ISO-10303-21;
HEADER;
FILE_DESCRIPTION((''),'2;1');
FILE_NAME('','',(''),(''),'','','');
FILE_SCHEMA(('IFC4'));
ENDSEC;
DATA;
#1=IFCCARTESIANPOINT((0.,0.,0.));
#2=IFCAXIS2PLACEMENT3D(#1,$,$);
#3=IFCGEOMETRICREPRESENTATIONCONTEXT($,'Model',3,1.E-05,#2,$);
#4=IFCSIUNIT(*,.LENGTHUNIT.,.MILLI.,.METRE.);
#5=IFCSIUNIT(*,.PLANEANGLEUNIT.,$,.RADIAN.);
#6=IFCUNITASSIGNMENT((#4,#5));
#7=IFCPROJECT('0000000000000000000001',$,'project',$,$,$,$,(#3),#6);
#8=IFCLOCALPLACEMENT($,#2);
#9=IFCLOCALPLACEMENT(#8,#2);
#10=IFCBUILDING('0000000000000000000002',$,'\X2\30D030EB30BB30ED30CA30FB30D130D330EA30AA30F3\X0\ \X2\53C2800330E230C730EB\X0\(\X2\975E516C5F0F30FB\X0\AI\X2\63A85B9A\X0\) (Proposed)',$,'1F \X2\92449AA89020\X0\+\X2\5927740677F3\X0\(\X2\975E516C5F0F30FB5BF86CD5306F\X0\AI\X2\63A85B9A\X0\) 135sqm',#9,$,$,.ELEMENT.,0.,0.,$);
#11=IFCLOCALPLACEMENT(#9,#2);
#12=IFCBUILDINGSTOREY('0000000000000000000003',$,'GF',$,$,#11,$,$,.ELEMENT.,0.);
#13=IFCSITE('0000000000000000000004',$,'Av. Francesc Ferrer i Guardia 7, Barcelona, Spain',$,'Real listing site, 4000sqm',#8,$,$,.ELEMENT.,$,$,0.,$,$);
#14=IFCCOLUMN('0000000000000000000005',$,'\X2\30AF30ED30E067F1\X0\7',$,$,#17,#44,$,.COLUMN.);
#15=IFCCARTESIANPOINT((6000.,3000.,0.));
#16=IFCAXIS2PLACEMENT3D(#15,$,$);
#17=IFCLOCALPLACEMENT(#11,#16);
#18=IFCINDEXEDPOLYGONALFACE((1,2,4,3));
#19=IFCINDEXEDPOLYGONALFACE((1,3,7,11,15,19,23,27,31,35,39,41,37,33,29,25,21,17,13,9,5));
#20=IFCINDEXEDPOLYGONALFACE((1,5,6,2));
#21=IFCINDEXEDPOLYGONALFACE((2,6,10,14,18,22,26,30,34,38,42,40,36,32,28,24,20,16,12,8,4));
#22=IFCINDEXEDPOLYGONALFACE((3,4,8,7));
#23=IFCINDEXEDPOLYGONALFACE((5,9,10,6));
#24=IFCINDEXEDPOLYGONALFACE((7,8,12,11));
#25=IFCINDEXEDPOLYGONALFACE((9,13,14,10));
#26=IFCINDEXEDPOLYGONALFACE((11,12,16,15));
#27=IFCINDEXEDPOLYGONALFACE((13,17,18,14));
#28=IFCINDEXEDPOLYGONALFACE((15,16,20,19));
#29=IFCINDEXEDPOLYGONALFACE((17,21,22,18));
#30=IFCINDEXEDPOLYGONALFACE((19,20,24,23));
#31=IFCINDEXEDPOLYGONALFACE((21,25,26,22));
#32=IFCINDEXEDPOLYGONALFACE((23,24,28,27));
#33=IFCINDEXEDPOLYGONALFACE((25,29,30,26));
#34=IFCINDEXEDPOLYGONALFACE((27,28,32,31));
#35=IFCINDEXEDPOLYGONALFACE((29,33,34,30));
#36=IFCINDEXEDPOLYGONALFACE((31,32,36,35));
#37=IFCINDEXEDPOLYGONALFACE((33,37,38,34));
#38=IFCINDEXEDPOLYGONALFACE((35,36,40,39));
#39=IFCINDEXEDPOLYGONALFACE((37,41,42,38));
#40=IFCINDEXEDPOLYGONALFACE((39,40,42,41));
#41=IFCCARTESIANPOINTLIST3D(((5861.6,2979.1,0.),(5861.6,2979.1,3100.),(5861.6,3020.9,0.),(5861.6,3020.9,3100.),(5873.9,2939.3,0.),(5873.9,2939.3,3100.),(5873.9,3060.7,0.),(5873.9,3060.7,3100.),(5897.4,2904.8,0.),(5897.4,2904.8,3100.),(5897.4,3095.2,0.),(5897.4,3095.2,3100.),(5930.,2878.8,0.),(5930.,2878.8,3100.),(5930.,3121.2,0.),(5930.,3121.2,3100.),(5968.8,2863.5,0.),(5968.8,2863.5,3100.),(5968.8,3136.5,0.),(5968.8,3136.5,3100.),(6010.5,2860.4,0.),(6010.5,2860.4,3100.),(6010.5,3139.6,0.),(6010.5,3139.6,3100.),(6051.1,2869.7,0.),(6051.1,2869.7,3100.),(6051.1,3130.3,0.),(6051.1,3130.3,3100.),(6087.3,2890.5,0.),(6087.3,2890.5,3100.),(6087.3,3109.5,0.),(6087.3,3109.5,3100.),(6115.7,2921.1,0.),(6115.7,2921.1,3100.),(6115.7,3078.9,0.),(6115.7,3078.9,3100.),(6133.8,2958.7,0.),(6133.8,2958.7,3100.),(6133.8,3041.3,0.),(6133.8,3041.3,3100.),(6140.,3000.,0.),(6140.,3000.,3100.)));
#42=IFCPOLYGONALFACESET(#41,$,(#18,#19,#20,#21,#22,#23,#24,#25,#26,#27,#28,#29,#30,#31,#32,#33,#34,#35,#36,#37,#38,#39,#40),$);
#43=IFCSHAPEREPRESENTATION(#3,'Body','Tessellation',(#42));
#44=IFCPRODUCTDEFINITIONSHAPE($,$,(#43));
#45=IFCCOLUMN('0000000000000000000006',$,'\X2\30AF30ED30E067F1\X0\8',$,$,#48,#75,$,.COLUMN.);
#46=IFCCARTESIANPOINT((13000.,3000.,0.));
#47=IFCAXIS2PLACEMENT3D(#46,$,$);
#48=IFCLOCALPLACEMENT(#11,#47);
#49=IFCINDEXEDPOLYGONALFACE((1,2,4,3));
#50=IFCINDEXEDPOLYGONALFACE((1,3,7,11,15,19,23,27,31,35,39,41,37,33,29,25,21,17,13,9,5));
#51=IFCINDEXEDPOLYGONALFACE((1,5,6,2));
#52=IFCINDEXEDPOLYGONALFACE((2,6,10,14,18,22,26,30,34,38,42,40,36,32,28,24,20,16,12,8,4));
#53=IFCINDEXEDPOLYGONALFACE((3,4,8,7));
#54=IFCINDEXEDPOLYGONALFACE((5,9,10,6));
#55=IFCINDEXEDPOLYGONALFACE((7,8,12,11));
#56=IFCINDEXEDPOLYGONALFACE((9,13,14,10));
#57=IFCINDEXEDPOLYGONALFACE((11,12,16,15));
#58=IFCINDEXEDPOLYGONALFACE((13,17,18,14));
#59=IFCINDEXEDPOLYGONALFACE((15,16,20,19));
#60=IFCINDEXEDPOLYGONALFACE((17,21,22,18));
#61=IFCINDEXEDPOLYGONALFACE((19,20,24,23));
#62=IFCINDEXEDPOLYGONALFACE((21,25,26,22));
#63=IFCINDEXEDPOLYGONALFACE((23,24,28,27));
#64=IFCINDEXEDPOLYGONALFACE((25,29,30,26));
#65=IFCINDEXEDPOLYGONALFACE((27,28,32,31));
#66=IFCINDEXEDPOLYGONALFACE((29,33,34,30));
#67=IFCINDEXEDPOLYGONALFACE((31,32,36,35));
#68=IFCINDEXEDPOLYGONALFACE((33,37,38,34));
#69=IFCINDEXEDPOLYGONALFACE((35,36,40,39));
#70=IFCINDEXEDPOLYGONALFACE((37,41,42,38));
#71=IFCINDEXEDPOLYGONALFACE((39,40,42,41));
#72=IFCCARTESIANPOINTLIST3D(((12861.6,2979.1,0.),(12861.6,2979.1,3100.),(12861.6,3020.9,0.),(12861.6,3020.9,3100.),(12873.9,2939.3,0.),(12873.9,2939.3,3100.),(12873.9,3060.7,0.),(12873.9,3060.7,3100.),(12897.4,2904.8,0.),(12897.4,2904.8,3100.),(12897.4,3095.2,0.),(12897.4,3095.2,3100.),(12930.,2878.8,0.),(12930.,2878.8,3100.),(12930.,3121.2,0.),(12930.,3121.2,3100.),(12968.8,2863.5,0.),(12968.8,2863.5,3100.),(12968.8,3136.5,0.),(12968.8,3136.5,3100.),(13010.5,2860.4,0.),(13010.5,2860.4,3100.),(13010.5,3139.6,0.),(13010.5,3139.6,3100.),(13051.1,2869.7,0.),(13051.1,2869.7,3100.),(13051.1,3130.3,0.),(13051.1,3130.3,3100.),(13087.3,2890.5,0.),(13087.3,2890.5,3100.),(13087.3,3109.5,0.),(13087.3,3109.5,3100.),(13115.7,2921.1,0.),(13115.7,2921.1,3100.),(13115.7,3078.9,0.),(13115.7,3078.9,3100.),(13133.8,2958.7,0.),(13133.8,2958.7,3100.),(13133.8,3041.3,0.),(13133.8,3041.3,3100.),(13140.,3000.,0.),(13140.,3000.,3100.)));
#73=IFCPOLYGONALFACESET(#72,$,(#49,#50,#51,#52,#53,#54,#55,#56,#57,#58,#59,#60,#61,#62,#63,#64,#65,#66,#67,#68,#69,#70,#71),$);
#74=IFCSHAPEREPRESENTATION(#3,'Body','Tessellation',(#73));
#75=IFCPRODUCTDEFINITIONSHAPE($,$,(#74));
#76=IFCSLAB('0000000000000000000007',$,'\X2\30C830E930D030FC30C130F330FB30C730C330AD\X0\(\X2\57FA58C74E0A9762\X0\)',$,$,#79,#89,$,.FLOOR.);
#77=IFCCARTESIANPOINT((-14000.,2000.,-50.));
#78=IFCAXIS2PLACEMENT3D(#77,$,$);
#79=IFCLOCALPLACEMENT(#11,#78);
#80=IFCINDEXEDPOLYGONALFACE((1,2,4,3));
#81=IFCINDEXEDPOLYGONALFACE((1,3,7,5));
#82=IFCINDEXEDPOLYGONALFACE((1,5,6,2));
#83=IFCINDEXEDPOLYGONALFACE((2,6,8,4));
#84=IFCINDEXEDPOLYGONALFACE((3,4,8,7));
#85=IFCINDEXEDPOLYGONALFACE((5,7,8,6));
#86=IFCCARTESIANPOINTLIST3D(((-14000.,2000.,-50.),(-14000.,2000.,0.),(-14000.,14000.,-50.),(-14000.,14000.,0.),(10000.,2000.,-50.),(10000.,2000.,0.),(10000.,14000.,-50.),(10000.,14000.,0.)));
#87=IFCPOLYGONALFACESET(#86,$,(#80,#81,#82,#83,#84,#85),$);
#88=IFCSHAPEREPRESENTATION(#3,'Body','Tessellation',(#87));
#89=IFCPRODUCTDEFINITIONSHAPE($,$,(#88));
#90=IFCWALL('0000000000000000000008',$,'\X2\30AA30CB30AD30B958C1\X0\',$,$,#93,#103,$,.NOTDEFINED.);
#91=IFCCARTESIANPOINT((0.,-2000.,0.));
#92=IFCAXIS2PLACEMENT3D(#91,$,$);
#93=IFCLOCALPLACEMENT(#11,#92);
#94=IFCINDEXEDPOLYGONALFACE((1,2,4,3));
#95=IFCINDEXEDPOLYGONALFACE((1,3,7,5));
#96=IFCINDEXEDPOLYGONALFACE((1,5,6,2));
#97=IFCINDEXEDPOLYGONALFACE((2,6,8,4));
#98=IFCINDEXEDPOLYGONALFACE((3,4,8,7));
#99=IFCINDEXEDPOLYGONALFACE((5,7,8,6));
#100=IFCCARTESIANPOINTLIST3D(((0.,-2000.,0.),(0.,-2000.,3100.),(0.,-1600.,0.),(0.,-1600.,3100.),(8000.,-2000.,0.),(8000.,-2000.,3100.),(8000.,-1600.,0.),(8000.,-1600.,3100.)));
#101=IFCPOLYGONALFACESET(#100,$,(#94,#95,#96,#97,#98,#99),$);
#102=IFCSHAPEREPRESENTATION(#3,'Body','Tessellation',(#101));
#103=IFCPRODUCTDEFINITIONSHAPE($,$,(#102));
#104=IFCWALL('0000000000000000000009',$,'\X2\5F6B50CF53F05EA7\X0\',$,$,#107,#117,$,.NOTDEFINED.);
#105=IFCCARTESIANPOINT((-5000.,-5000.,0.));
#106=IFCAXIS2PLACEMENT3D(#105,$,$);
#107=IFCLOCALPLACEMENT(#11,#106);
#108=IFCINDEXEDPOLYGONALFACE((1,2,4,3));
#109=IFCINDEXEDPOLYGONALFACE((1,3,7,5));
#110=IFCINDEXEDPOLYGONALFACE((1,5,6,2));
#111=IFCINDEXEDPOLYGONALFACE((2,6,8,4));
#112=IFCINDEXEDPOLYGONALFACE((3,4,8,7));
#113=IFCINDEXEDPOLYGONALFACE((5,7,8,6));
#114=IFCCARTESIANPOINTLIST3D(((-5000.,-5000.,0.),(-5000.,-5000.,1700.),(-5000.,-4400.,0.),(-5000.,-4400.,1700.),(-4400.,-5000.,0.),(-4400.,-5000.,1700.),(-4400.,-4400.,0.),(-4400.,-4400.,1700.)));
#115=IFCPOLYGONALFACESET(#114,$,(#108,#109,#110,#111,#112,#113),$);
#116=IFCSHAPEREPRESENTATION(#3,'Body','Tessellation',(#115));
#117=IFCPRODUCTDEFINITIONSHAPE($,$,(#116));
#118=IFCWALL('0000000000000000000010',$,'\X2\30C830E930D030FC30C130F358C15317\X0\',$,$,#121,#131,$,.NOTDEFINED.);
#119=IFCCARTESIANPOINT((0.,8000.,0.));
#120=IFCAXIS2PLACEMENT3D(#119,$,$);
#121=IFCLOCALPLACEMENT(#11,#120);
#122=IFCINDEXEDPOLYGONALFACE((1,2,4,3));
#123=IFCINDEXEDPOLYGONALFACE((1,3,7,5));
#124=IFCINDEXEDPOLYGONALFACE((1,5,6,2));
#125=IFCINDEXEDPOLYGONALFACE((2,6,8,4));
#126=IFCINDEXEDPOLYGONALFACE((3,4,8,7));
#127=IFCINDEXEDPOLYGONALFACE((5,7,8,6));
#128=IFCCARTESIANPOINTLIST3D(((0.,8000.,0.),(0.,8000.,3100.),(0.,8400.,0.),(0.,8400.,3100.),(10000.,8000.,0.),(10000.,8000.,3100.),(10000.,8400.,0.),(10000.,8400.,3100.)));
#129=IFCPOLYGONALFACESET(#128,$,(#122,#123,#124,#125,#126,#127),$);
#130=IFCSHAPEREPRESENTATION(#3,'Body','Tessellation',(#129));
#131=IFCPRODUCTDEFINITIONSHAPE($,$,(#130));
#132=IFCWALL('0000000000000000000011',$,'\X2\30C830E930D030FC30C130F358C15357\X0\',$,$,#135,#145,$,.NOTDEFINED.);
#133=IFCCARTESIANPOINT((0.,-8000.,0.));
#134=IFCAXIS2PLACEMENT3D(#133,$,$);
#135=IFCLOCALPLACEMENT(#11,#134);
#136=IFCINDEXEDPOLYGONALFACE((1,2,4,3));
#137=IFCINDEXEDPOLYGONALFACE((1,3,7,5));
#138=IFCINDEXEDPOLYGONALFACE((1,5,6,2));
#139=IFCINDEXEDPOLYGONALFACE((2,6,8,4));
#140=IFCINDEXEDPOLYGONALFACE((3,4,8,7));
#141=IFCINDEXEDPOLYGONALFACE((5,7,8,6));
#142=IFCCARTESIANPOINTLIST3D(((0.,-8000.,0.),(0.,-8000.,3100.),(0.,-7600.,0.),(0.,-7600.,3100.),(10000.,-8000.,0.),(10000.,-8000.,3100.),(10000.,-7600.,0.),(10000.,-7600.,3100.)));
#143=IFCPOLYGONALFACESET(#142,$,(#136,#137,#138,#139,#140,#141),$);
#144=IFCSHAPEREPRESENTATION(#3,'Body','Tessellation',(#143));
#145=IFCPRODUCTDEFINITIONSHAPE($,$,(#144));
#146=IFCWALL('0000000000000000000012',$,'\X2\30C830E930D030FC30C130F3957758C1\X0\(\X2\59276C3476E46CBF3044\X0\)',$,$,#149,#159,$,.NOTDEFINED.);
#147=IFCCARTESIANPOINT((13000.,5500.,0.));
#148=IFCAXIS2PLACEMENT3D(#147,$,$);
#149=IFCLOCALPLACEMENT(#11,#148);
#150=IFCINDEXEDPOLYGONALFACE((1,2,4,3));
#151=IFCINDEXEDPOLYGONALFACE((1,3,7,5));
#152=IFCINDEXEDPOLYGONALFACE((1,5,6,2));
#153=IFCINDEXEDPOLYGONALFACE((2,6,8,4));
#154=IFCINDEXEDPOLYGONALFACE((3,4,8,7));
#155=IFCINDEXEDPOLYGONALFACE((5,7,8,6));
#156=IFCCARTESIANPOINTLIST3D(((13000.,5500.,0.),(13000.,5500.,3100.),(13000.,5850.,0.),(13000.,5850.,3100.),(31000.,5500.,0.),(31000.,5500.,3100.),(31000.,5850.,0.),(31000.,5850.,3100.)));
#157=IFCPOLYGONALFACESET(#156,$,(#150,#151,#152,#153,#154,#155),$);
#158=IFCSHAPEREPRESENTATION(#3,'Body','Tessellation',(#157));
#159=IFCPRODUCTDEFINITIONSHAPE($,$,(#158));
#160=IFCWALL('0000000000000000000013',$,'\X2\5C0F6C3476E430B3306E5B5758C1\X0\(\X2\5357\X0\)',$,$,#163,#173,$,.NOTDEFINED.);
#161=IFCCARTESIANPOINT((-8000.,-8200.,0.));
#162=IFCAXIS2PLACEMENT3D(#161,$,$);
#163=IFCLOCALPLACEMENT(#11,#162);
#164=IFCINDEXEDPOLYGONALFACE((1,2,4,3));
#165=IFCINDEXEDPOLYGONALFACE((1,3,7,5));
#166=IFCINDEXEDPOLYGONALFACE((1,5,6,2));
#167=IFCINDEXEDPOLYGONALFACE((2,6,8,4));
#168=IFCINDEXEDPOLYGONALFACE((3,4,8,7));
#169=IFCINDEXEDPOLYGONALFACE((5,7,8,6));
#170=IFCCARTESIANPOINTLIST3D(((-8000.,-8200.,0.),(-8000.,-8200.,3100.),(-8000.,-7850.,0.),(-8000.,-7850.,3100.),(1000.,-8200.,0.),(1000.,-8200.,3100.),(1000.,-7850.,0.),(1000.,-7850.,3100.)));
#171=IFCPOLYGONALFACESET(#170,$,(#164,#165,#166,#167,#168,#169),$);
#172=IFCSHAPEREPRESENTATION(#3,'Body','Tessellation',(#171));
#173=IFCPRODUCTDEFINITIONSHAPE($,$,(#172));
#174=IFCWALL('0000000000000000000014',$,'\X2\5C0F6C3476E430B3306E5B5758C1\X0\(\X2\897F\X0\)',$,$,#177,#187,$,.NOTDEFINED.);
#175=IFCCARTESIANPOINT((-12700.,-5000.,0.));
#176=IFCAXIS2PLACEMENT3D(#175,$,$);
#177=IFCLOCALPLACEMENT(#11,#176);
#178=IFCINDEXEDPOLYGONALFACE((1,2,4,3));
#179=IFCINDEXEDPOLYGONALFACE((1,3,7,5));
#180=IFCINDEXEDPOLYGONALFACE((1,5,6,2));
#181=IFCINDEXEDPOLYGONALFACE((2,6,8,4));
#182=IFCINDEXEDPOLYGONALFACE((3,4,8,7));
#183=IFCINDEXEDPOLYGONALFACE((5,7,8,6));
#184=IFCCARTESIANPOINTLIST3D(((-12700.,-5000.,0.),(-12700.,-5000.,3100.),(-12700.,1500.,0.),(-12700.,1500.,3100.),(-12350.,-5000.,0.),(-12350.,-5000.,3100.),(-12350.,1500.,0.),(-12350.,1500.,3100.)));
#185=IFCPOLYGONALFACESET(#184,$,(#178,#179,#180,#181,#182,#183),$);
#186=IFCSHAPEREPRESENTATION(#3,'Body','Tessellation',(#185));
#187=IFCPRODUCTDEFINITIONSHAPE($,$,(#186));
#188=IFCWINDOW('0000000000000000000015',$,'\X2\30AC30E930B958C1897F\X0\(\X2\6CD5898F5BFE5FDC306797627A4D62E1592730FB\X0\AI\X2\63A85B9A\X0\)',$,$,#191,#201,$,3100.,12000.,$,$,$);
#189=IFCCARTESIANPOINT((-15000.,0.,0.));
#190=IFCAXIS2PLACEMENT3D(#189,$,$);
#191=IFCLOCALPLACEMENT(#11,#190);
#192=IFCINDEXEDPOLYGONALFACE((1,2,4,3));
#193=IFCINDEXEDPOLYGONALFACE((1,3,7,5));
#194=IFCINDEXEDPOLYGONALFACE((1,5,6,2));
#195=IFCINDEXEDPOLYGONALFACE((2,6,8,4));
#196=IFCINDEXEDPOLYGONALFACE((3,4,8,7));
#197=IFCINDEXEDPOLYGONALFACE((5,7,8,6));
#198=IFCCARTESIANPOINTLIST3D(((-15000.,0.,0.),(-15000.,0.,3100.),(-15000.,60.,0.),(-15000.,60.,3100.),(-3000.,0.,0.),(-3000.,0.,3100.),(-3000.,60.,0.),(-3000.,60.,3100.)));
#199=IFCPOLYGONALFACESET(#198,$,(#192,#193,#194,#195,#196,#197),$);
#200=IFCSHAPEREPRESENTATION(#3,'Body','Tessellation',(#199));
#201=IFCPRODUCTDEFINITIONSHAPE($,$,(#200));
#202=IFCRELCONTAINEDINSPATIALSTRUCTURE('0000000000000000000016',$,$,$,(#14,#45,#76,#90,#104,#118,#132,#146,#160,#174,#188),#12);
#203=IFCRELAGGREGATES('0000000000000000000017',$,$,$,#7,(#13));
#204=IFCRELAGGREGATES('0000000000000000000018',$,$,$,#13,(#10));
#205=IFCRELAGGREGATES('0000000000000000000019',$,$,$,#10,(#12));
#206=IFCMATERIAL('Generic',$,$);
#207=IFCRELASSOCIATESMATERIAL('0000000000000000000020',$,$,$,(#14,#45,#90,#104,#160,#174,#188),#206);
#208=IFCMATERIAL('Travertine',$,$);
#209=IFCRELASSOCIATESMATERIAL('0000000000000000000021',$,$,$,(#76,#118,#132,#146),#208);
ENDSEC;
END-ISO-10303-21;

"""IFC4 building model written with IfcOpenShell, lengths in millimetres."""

from ifc_helpers import new_model, si_unit, frame, frame_2d, origin, origin_2d, place, context, project, spatial, rectangle, circle, extrude, material, element, fill, save


model = new_model("IFC4")

# Units and contexts
model_context = context("Model", 3, precision=1e-05, world=origin())
ifc_project = project(units=[si_unit("LENGTHUNIT", "METRE", prefix="MILLI"), si_unit("PLANEANGLEUNIT", "RADIAN")], contexts=[model_context])

# Site, building, storey
site_placement = place(None, origin())
site = spatial("IfcSite", under=ifc_project, at=site_placement, Name="Av. Francesc Ferrer i Guardia 7, Barcelona, Spain", ObjectType="Real listing site, 4000sqm", CompositionType="ELEMENT", RefElevation=0.0)
building_placement = place(site_placement, origin())
building = spatial("IfcBuilding", under=site, at=building_placement, Name="バルセロナ・パビリオン 参考モデル(非公式・AI推定) (Proposed)", ObjectType="1F 鉄骨造+大理石(非公式・寸法はAI推定) 135sqm", CompositionType="ELEMENT", ElevationOfRefHeight=0.0, ElevationOfTerrain=0.0)
storey_placement = place(building_placement, origin())
storey = spatial("IfcBuildingStorey", under=building, at=storey_placement, Name="GF", CompositionType="ELEMENT", Elevation=0.0)

# Shared definitions
ifc_material_1 = material(Name="Travertine")

# Columns
ifc_material_2 = material(Name="Generic")
column_1_placement = place(storey_placement, frame((6000.0, 3000.0, 0.0)))
element("IfcColumn", 1, at=column_1_placement, inside=storey, material=ifc_material_2, Name="クロム柱7", PredefinedType="COLUMN", context=model_context, shape_type="SweptSolid", body=[
    extrude(circle(Radius=140.0, at=origin_2d()), frame((6000.0, 3000.0, 0.0)), (0.0, 0.0, 1.0), 3100.0),
])
column_2_placement = place(storey_placement, frame((13000.0, 3000.0, 0.0)))
element("IfcColumn", 2, at=column_2_placement, inside=storey, material=ifc_material_2, Name="クロム柱8", PredefinedType="COLUMN", context=model_context, shape_type="SweptSolid", body=[
    extrude(circle(Radius=140.0, at=origin_2d()), frame((13000.0, 3000.0, 0.0)), (0.0, 0.0, 1.0), 3100.0),
])

# Slab
slab_1_placement = place(storey_placement, frame((-14000.0, 2000.0, -50.0)))
element("IfcSlab", 3, at=slab_1_placement, inside=storey, material=ifc_material_1, Name="トラバーチン・デッキ(基壇上面)", PredefinedType="FLOOR", context=model_context, shape_type="SweptSolid", body=[
    extrude(rectangle(XDim=24000.0, YDim=12000.0, at=frame_2d((12000.0, 6000.0))), frame((-14000.0, 2000.0, -50.0)), (0.0, 0.0, 1.0), 50.0),
])

# Walls
wall_1_placement = place(storey_placement, frame((0.0, -2000.0, 0.0)))
element("IfcWall", 4, at=wall_1_placement, inside=storey, material=ifc_material_2, Name="オニキス壁", PredefinedType="NOTDEFINED", context=model_context, shape_type="SweptSolid", body=[
    extrude(rectangle(XDim=8000.0, YDim=400.0, at=frame_2d((4000.0, 200.0))), frame((0.0, -2000.0, 0.0)), (0.0, 0.0, 1.0), 3100.0),
])
wall_2_placement = place(storey_placement, frame((-5000.0, -5000.0, 0.0)))
element("IfcWall", 5, at=wall_2_placement, inside=storey, material=ifc_material_2, Name="彫像台座", PredefinedType="NOTDEFINED", context=model_context, shape_type="SweptSolid", body=[
    extrude(rectangle(XDim=600.0, YDim=600.0, at=frame_2d((300.0, 300.0))), frame((-5000.0, -5000.0, 0.0)), (0.0, 0.0, 1.0), 1700.0),
])

# Walls
wall_3_placement = place(storey_placement, frame((0.0, 8000.0, 0.0)))
element("IfcWall", 6, at=wall_3_placement, inside=storey, material=ifc_material_1, Name="トラバーチン壁北", PredefinedType="NOTDEFINED", context=model_context, shape_type="SweptSolid", body=[
    extrude(rectangle(XDim=10000.0, YDim=400.0, at=frame_2d((5000.0, 200.0))), frame((0.0, 8000.0, 0.0)), (0.0, 0.0, 1.0), 3100.0),
])
wall_4_placement = place(storey_placement, frame((0.0, -8000.0, 0.0)))
element("IfcWall", 7, at=wall_4_placement, inside=storey, material=ifc_material_1, Name="トラバーチン壁南", PredefinedType="NOTDEFINED", context=model_context, shape_type="SweptSolid", body=[
    extrude(rectangle(XDim=10000.0, YDim=400.0, at=frame_2d((5000.0, 200.0))), frame((0.0, -8000.0, 0.0)), (0.0, 0.0, 1.0), 3100.0),
])

# Walls
wall_5_placement = place(storey_placement, frame((13000.0, 5500.0, 0.0)))
element("IfcWall", 8, at=wall_5_placement, inside=storey, material=ifc_material_1, Name="トラバーチン長壁(大水盤沿い)", PredefinedType="NOTDEFINED", context=model_context, shape_type="SweptSolid", body=[
    extrude(rectangle(XDim=18000.0, YDim=350.0, at=frame_2d((9000.0, 175.0))), frame((13000.0, 5500.0, 0.0)), (0.0, 0.0, 1.0), 3100.0),
])
wall_6_placement = place(storey_placement, frame((-8000.0, -8200.0, 0.0)))
element("IfcWall", 9, at=wall_6_placement, inside=storey, material=ifc_material_2, Name="小水盤コの字壁(南)", PredefinedType="NOTDEFINED", context=model_context, shape_type="SweptSolid", body=[
    extrude(rectangle(XDim=9000.0, YDim=350.0, at=frame_2d((4500.0, 175.0))), frame((-8000.0, -8200.0, 0.0)), (0.0, 0.0, 1.0), 3100.0),
])

# Wall, opening, window
wall_7_placement = place(storey_placement, frame((-12700.0, -5000.0, 0.0)))
wall_7 = element("IfcWall", 10, at=wall_7_placement, inside=storey, material=ifc_material_2, Name="小水盤コの字壁(西)", PredefinedType="NOTDEFINED", context=model_context, shape_type="SweptSolid", body=[
    extrude(rectangle(XDim=350.0, YDim=6500.0, at=frame_2d((175.0, 3250.0))), frame((-12700.0, -5000.0, 0.0)), (0.0, 0.0, 1.0), 3100.0),
])
opening_1_placement = place(storey_placement, frame((-15000.0, 0.0, 0.0)))
opening_1 = element("IfcOpeningElement", 11, at=opening_1_placement, cuts=wall_7, PredefinedType="NOTDEFINED", context=model_context, shape_type="SweptSolid", body=[
    extrude(rectangle(XDim=12000.0, YDim=60.0, at=frame_2d((6000.0, 30.0))), frame((-15000.0, 0.0, 0.0)), (0.0, 0.0, 1.0), 3100.0),
])
window_1_placement = place(storey_placement, frame((-15000.0, 0.0, 0.0)))
window_1 = element("IfcWindow", 12, at=window_1_placement, inside=storey, material=ifc_material_2, Name="ガラス壁西(法規対応で面積拡大・AI推定)", OverallHeight=3100.0, OverallWidth=12000.0, context=model_context, shape_type="SweptSolid", body=[
    extrude(rectangle(XDim=12000.0, YDim=60.0, at=frame_2d((6000.0, 30.0))), frame((-15000.0, 0.0, 0.0)), (0.0, 0.0, 1.0), 3100.0),
])
fill(opening_1, window_1)

save(model, "model.ifc")
